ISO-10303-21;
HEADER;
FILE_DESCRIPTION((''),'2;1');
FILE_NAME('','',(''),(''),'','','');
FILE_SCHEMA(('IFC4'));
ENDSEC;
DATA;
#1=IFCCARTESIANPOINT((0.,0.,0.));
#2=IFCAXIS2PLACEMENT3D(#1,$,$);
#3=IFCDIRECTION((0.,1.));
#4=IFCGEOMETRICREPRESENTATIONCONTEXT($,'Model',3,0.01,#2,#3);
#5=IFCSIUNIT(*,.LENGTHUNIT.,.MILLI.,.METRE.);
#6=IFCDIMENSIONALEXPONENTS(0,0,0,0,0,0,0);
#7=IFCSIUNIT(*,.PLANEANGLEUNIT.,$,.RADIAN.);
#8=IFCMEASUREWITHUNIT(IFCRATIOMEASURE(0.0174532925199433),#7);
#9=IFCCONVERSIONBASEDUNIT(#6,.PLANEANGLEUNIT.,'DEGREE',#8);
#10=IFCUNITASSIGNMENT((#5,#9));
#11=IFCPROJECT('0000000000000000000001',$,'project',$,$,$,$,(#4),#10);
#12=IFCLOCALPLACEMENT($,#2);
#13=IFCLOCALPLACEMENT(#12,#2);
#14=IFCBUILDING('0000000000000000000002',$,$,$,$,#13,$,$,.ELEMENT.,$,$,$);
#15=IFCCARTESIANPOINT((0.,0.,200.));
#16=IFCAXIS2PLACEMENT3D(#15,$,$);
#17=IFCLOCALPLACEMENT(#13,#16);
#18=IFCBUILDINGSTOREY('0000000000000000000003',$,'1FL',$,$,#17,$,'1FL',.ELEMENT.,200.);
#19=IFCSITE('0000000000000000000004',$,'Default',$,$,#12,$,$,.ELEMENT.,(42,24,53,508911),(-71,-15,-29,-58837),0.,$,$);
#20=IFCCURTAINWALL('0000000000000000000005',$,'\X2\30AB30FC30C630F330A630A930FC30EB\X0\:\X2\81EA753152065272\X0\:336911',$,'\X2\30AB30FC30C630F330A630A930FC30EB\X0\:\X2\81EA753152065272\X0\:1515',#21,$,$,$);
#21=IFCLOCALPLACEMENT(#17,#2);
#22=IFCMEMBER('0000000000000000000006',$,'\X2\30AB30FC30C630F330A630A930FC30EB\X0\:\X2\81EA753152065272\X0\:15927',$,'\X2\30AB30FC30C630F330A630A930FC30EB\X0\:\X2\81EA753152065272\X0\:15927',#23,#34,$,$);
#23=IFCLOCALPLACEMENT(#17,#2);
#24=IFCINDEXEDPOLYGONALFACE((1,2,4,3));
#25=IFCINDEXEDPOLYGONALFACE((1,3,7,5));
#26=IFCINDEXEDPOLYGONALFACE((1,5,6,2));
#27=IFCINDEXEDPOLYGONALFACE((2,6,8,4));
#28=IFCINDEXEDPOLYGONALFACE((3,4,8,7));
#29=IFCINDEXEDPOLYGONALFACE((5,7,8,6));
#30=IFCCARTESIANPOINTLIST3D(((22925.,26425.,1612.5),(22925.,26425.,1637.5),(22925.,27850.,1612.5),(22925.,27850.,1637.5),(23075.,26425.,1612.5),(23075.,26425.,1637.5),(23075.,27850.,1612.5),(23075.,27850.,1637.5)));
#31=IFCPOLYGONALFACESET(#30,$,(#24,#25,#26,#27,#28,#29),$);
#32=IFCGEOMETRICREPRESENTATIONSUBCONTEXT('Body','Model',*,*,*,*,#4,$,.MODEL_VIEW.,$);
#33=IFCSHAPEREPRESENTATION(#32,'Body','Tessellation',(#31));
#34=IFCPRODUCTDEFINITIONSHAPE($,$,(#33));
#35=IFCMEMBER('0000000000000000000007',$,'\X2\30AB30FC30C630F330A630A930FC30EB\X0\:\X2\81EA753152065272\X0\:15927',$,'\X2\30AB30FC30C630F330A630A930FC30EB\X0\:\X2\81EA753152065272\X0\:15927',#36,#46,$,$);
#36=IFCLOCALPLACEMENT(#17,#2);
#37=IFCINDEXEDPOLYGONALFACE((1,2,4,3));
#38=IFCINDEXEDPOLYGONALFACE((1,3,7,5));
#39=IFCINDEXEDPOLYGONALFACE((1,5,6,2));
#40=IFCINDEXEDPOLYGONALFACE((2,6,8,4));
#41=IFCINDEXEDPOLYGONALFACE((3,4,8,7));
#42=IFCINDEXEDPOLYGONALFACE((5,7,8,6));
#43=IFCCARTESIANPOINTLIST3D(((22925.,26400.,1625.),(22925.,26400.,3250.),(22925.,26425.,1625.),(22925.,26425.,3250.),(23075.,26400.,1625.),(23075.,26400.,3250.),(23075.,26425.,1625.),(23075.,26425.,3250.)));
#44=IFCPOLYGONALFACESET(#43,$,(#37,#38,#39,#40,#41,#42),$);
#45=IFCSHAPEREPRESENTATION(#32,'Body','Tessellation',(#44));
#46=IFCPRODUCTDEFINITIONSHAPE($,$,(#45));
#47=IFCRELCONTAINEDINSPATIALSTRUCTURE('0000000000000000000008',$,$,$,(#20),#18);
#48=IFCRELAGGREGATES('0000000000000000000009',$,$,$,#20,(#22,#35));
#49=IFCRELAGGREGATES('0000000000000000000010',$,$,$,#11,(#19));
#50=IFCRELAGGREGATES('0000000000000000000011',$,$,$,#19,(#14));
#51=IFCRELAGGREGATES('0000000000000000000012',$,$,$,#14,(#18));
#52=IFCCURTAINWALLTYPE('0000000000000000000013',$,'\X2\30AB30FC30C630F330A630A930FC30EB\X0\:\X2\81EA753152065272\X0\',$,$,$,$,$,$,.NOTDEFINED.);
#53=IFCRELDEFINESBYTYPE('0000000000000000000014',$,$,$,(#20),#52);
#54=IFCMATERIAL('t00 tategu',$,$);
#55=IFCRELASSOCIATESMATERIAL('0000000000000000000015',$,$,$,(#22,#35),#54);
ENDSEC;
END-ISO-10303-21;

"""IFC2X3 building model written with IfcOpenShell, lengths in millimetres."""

from ifc_helpers import new_model, entity, si_unit, converted_unit, direction, frame, frame_2d, origin, origin_2d_with_axis, place, context, subcontext, project, spatial, rectangle, extrude, material, type_object, element, aggregate, save


model = new_model("IFC2X3")

# Units and contexts
model_context = context("Model", 3, precision=0.01, world=origin(), true_north=direction((0.0, 1.0)))
body_context = subcontext(model_context, "Body", "Model", "MODEL_VIEW")
ifc_project = project(units=[si_unit("LENGTHUNIT", "METRE", prefix="MILLI"), converted_unit("PLANEANGLEUNIT", "DEGREE", entity("IfcRatioMeasure", 0.0174532925199433), si_unit("PLANEANGLEUNIT", "RADIAN"), dimensions=[0, 0, 0, 0, 0, 0, 0])], contexts=[model_context])

# Site, building, storey
site_placement = place(None, origin())
site = spatial("IfcSite", under=ifc_project, at=site_placement, Name="Default", CompositionType="ELEMENT", RefLatitude=(42, 24, 53, 508911), RefLongitude=(-71, -15, -29, -58837), RefElevation=0.0)
building_placement = place(site_placement, origin())
building = spatial("IfcBuilding", under=site, at=building_placement, CompositionType="ELEMENT")
storey_placement = place(building_placement, frame((0.0, 0.0, 200.0)))
storey = spatial("IfcBuildingStorey", under=building, at=storey_placement, Name="1FL", LongName="1FL", CompositionType="ELEMENT", Elevation=200.0)

# Curtain wall, members
curtain_wall_type = type_object("IfcCurtainWallType", Name="カーテンウォール:自由分割", PredefinedType="NOTDEFINED")
ifc_material = material(Name="t00 tategu")
curtain_wall_1_placement = place(storey_placement, frame((0.0, 0.0, -200.0)))
curtain_wall_1 = element("IfcCurtainWall", 1, at=curtain_wall_1_placement, inside=storey, type_object=curtain_wall_type, Name="カーテンウォール:自由分割:336911", ObjectType="カーテンウォール:自由分割:1515")
member_1_placement = place(curtain_wall_1_placement, frame((0.0, 0.0, 200.0)))
member_1 = element("IfcMember", 2, at=member_1_placement, material=ifc_material, Name="カーテンウォール:自由分割:15927", ObjectType="カーテンウォール:自由分割:15927", context=body_context, shape_type="SweptSolid", body=[
    extrude(rectangle(XDim=25.0, YDim=150.0, at=origin_2d_with_axis()), frame((23000.0, 26425.0, 1625.0), z_axis=(0.0, 1.0, 0.0), x_axis=(0.0, 0.0, -1.0)), (0.0, 0.0, 1.0), 1425.0),
])
member_2_placement = place(curtain_wall_1_placement, frame((0.0, 0.0, 200.0)))
member_2 = element("IfcMember", 3, at=member_2_placement, material=ifc_material, Name="カーテンウォール:自由分割:15927", ObjectType="カーテンウォール:自由分割:15927", context=body_context, shape_type="SweptSolid", body=[
    extrude(rectangle(XDim=150.0, YDim=25.0, at=frame_2d((0.0, 0.0), x_axis=(1.0, 0.0))), frame((23000.0, 26412.5, 1625.0), z_axis=(0.0, 0.0, 1.0), x_axis=(-1.0, 0.0, 0.0)), (0.0, 0.0, 1.0), 1625.0),
])
aggregate(curtain_wall_1, [member_1, member_2])

save(model, "model.ifc")
